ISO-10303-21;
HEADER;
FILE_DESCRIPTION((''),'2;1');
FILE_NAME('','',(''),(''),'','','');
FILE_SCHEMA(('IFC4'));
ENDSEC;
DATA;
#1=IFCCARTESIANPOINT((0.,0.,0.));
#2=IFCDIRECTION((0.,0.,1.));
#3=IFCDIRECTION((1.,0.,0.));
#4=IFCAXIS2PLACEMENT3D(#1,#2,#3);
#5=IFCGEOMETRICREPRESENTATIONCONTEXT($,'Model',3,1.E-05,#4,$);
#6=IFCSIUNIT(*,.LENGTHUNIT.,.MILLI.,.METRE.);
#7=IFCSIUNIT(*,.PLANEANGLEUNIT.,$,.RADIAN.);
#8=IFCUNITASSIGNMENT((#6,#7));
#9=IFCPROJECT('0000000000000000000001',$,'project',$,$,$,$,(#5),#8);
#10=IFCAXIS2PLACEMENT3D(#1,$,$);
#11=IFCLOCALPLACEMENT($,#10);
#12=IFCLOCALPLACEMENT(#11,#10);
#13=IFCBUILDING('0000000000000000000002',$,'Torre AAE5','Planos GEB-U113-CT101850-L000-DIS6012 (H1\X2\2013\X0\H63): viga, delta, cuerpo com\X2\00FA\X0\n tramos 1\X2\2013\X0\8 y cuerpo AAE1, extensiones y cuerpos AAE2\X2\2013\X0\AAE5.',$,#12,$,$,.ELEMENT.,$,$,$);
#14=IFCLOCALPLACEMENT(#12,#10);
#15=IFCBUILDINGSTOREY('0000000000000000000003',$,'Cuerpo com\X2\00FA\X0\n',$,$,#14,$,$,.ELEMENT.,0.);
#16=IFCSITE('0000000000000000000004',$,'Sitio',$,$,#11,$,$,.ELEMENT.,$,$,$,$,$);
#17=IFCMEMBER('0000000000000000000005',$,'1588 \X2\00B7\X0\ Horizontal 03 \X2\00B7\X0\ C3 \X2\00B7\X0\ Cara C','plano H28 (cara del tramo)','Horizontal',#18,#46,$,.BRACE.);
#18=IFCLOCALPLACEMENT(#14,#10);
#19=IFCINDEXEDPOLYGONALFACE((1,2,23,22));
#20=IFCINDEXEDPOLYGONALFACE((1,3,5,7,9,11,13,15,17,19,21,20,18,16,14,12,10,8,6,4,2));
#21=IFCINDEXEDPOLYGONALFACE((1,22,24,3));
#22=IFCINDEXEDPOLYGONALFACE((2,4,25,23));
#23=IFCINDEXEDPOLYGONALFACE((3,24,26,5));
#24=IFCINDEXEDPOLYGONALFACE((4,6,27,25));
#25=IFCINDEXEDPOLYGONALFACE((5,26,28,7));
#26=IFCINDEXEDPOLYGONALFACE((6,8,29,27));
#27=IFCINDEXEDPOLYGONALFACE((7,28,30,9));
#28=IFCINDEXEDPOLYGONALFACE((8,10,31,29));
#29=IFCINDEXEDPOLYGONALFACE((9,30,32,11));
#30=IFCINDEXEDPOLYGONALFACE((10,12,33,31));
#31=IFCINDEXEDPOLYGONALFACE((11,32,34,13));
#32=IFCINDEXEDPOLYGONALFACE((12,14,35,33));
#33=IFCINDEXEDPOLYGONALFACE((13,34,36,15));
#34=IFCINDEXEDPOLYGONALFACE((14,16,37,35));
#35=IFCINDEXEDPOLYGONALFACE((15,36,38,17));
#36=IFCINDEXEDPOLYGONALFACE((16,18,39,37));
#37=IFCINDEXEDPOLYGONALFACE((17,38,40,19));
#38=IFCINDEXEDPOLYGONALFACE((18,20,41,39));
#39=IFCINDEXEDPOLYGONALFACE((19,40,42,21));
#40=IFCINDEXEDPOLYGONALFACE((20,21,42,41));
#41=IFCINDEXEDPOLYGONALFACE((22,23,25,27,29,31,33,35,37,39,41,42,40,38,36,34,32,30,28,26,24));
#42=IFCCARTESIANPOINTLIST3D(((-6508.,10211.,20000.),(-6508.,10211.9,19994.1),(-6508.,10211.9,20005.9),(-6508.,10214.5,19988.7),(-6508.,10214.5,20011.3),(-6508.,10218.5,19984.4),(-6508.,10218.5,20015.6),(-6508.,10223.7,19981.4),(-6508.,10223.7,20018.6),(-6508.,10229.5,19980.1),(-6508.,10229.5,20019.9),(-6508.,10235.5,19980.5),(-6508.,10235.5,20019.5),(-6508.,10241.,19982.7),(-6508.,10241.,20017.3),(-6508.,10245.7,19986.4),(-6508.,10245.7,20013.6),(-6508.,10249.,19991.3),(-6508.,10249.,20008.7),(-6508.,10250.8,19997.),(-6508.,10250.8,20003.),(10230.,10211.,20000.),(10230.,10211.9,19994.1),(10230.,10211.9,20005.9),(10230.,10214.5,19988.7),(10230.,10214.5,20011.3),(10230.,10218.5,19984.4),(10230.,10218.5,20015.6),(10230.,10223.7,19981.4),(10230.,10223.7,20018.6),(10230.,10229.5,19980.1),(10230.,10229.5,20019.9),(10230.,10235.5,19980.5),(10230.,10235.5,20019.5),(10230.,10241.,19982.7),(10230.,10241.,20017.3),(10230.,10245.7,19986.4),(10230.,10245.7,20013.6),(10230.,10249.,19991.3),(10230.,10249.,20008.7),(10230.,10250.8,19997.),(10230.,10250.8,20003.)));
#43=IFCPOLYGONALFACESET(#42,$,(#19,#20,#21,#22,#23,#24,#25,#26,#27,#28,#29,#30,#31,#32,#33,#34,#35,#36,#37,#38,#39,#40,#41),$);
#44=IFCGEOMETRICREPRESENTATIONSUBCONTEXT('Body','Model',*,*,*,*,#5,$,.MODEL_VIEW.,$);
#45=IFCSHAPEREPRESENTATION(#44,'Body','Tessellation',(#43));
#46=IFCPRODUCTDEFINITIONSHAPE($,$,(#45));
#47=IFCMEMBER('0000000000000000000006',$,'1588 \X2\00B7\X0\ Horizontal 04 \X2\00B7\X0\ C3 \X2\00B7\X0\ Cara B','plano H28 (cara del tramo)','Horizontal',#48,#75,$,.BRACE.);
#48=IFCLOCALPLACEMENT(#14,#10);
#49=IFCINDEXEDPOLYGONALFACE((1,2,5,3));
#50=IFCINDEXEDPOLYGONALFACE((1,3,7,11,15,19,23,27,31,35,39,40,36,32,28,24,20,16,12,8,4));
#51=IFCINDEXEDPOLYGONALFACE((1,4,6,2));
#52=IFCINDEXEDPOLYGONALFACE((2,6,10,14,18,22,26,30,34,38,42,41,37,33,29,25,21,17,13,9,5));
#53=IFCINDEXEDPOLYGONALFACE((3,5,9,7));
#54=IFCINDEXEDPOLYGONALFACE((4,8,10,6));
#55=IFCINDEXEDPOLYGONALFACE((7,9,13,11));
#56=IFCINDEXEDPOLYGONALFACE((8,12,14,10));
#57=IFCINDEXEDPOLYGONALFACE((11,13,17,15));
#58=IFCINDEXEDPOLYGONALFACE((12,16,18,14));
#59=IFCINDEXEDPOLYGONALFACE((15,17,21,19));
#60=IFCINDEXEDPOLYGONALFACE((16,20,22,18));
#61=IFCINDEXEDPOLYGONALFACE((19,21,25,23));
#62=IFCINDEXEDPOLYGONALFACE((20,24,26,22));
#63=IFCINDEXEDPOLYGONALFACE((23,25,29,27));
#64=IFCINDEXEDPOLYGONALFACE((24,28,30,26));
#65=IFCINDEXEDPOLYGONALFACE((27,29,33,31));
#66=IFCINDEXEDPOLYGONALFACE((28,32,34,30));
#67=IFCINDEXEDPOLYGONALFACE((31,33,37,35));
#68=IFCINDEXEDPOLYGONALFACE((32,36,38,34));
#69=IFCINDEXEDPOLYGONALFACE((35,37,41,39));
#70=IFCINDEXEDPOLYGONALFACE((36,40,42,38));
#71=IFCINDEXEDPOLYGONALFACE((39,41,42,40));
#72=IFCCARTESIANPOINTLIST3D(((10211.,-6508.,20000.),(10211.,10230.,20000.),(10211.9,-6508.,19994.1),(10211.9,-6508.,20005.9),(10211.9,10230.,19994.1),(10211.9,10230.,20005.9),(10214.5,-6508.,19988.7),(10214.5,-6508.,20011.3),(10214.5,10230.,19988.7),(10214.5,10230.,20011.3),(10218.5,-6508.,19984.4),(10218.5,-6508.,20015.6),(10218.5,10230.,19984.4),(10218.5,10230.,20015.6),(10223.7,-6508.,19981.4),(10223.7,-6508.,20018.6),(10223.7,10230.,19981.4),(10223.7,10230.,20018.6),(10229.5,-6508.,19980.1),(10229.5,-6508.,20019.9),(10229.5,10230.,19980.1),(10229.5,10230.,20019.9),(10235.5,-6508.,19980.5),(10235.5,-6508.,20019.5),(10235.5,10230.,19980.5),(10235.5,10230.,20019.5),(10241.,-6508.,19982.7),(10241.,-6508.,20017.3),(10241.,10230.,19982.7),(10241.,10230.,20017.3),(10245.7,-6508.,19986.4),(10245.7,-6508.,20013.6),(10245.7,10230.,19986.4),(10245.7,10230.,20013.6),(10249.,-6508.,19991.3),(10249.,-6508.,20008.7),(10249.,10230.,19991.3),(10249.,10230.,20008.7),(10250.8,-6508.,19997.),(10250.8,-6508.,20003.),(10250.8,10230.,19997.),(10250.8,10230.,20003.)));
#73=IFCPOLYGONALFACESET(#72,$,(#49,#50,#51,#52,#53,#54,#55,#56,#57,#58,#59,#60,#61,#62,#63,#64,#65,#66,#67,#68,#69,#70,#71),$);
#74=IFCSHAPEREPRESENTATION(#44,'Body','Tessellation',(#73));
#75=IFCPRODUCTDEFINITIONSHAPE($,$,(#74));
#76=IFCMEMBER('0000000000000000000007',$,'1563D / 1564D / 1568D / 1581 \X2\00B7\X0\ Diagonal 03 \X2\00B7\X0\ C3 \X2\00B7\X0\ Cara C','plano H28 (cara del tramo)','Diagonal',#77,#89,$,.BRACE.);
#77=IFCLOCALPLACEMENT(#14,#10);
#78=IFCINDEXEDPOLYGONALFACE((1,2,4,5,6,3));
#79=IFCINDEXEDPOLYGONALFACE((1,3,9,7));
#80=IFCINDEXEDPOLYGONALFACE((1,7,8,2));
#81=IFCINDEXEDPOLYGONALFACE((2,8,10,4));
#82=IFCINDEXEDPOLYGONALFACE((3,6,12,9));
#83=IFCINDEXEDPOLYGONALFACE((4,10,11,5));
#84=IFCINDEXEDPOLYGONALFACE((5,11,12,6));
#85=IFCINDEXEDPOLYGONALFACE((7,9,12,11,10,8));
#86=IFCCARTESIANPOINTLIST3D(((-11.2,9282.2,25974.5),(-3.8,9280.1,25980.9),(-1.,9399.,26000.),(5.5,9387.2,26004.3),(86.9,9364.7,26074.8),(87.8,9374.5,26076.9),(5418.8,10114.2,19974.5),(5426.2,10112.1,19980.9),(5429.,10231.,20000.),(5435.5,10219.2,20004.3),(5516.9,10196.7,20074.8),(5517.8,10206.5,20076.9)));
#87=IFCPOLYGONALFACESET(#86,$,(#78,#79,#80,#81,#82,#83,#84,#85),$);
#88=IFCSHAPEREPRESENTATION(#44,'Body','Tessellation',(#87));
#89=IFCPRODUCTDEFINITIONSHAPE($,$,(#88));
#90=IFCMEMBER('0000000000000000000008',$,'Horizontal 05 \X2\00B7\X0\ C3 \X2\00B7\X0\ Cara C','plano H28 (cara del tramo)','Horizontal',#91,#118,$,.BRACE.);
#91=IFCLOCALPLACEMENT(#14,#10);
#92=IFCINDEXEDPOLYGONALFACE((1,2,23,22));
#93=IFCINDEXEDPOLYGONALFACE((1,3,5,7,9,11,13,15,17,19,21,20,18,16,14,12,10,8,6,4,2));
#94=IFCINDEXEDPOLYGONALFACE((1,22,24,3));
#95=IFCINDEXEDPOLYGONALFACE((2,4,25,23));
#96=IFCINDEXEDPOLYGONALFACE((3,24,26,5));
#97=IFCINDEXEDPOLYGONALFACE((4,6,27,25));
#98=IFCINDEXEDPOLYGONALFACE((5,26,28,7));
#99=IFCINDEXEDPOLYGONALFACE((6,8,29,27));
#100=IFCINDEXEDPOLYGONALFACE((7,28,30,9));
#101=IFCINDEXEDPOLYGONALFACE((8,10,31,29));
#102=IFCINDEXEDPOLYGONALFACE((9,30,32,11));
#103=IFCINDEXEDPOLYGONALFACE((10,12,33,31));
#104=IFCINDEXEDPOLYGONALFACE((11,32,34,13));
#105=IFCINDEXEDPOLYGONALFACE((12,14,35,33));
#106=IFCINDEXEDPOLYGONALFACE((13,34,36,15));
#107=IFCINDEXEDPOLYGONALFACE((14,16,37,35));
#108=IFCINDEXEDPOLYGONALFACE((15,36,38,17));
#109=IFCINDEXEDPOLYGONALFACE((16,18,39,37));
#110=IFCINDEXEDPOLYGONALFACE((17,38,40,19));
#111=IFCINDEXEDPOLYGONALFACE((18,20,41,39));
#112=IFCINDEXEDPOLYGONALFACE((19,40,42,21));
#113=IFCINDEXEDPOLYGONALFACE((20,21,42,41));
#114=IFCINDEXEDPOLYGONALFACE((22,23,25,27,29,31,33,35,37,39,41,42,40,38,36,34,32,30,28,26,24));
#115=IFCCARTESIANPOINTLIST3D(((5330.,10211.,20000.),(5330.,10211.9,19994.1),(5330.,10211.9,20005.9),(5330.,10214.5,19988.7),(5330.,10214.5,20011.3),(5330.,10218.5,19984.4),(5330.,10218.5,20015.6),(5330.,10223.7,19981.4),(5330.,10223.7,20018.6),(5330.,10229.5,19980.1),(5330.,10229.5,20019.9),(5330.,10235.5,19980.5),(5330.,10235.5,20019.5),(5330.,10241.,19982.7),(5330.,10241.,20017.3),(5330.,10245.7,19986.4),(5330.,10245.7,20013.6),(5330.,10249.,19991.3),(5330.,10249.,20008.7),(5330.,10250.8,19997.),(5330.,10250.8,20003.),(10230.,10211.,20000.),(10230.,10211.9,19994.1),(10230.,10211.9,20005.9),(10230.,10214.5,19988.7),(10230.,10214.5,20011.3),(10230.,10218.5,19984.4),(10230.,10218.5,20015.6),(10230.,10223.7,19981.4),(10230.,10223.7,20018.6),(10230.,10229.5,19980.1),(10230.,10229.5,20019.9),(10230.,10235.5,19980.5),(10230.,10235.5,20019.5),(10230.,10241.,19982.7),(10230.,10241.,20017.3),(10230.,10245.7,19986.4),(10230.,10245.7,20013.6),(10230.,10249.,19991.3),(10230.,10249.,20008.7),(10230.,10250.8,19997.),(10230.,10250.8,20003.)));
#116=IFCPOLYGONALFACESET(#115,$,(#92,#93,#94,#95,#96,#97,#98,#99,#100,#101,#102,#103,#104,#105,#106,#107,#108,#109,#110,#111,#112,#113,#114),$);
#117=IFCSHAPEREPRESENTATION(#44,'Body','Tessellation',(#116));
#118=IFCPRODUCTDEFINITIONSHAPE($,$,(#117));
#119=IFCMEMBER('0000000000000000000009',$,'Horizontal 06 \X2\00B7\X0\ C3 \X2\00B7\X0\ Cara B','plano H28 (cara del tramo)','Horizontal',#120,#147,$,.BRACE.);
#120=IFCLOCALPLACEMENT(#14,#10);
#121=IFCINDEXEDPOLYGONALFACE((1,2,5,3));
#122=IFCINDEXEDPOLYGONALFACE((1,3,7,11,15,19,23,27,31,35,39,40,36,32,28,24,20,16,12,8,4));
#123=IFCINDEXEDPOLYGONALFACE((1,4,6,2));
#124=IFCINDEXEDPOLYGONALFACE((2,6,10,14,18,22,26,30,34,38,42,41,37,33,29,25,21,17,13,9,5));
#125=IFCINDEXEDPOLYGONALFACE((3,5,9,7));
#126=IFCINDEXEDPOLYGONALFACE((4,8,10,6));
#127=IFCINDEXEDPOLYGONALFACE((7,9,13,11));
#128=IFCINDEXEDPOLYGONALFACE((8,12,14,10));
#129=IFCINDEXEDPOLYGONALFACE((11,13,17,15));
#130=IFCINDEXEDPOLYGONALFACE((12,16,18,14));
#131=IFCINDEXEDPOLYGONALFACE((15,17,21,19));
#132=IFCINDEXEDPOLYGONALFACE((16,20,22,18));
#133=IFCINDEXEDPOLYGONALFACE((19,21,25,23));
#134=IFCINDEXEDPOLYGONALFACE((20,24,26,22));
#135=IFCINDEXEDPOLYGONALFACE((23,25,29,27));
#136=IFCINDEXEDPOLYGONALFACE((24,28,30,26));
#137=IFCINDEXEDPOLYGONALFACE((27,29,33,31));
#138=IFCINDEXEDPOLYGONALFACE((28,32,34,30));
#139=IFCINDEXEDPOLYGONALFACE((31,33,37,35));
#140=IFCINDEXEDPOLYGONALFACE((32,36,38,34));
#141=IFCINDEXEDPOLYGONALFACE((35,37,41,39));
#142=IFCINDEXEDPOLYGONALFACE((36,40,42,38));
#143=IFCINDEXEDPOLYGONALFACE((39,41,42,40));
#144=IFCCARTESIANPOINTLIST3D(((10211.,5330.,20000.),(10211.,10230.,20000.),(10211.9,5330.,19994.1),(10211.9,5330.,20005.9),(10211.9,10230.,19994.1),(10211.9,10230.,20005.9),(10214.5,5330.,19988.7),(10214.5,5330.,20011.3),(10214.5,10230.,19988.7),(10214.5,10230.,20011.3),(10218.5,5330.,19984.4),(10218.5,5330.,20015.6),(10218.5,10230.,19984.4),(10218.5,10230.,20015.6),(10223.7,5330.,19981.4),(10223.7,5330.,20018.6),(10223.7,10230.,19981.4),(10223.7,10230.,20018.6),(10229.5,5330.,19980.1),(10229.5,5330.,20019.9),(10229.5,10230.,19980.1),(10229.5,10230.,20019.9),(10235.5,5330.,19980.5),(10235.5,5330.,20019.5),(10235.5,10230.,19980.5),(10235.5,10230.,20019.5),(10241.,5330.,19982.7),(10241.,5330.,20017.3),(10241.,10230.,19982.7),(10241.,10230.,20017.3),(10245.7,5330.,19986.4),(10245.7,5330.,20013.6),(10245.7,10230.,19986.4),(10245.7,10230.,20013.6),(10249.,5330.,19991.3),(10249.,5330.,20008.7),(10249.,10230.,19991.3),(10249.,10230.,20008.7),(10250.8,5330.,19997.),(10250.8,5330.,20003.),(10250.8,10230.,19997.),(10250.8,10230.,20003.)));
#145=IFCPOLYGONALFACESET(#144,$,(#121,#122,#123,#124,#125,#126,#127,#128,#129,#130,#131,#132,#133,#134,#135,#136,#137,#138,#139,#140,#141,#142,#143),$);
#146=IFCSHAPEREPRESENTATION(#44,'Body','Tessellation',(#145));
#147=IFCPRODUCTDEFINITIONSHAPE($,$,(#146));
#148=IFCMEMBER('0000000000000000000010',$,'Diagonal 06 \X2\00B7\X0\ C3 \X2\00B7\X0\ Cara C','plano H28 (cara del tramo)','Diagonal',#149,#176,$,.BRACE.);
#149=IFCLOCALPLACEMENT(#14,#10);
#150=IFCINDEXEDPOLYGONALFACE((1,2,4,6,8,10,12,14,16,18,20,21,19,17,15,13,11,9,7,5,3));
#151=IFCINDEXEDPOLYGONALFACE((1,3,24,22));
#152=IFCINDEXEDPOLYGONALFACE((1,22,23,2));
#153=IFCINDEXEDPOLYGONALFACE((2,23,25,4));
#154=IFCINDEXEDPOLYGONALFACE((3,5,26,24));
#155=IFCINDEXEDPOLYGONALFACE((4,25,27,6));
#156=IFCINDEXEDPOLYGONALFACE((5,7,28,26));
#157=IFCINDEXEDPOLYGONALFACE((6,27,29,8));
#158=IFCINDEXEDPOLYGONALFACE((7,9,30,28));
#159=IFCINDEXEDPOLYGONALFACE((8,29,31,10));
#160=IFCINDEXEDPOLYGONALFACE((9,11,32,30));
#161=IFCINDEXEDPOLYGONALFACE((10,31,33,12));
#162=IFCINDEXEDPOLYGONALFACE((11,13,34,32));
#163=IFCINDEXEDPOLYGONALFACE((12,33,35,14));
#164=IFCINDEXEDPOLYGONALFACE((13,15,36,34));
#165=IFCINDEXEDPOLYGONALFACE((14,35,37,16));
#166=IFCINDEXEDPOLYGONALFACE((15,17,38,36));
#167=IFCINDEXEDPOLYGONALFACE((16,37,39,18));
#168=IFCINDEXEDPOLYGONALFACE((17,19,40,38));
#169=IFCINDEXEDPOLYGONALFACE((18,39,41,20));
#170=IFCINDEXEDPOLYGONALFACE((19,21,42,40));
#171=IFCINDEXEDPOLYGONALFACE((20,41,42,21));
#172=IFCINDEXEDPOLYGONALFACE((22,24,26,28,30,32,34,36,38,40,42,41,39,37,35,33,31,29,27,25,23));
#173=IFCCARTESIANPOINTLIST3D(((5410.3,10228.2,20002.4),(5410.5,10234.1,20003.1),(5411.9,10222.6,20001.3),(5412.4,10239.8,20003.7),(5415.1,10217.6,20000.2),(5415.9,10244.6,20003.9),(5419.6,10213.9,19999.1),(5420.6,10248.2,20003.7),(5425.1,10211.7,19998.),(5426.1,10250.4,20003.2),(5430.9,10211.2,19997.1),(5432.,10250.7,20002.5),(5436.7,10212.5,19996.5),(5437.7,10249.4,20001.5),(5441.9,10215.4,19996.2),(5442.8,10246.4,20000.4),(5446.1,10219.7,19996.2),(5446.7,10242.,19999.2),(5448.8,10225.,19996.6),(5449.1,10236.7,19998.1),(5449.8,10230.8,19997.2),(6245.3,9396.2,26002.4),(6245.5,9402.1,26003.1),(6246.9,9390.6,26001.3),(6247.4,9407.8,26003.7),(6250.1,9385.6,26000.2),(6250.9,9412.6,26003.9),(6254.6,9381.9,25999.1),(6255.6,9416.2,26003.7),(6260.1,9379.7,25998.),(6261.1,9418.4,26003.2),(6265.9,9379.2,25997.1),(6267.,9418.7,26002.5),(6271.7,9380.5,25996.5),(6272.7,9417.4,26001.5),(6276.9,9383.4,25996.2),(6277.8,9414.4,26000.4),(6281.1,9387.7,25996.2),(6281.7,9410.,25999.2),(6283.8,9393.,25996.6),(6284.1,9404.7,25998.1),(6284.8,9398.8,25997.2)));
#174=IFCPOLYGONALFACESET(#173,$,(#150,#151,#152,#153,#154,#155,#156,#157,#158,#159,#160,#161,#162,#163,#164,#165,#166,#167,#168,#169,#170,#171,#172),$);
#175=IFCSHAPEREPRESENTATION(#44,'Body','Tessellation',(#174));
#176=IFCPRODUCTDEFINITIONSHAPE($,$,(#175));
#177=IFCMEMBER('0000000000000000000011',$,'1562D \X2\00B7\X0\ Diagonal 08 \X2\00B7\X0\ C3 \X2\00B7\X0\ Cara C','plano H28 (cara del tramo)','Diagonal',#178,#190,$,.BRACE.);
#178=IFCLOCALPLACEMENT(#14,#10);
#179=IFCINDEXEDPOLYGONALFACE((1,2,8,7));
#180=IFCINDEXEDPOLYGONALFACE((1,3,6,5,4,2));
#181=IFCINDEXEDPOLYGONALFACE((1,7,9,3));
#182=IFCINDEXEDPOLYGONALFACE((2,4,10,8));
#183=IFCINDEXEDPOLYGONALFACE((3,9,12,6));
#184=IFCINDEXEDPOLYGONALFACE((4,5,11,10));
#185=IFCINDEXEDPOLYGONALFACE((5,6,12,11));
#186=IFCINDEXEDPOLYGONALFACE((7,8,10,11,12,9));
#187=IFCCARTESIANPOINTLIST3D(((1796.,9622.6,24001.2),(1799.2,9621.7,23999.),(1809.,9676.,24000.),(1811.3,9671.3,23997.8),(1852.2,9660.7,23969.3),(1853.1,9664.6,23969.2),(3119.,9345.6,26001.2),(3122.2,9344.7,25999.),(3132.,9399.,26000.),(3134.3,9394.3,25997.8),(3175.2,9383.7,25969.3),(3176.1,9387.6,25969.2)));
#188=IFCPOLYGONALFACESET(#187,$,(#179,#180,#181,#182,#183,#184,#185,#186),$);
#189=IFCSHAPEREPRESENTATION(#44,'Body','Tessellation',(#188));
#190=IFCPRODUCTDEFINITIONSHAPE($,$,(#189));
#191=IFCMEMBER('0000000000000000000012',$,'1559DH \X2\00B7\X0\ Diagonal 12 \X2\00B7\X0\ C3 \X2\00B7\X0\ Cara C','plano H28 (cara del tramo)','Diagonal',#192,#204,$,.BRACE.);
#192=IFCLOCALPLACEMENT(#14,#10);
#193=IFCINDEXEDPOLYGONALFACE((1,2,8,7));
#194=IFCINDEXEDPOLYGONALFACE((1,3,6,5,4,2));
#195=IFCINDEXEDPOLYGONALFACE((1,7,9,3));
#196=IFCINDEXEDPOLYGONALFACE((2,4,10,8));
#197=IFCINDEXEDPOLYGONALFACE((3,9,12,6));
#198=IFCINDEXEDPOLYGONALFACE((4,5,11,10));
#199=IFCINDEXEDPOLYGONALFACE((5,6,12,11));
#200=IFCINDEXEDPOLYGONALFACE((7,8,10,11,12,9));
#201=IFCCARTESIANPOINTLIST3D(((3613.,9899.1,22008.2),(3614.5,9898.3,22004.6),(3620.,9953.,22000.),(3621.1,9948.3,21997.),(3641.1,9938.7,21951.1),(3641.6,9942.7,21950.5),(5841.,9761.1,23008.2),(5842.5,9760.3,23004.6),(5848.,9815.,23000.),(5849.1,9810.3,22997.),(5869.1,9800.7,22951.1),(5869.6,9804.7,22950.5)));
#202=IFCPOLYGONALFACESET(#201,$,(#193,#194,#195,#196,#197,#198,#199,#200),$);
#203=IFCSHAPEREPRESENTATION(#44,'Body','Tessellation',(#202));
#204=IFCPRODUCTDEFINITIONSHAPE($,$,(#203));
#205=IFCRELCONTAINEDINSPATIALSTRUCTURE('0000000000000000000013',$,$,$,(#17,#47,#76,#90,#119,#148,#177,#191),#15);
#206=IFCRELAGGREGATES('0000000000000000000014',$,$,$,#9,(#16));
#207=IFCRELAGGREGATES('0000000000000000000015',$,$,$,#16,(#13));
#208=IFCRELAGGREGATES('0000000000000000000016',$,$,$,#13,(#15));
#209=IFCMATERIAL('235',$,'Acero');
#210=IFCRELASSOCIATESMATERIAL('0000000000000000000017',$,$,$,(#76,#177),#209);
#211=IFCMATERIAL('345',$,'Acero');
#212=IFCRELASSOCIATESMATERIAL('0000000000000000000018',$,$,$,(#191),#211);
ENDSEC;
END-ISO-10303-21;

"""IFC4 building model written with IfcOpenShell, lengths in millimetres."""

from ifc_helpers import new_model, si_unit, frame, frame_2d, origin, origin_with_axes, place, context, subcontext, project, spatial, circle, l_section, extrude, material, element, save


model = new_model("IFC4")

# Units and contexts
model_context = context("Model", 3, precision=1e-05, world=origin_with_axes())
body_context = subcontext(model_context, "Body", "Model", "MODEL_VIEW")
ifc_project = project(units=[si_unit("LENGTHUNIT", "METRE", prefix="MILLI"), si_unit("PLANEANGLEUNIT", "RADIAN")], contexts=[model_context])

# Site, building, storey
site_placement = place(None, origin())
site = spatial("IfcSite", under=ifc_project, at=site_placement, Name="Sitio", CompositionType="ELEMENT")
building_placement = place(site_placement, origin())
building = spatial("IfcBuilding", under=site, at=building_placement, Name="Torre AAE5", Description="Planos GEB-U113-CT101850-L000-DIS6012 (H1–H63): viga, delta, cuerpo común tramos 1–8 y cuerpo AAE1, extensiones y cuerpos AAE2–AAE5.", CompositionType="ELEMENT")
storey_placement = place(building_placement, origin())
storey = spatial("IfcBuildingStorey", under=building, at=storey_placement, Name="Cuerpo común", CompositionType="ELEMENT", Elevation=0.0)

# Members
for number, where, z_axis, x_axis, name in (
    (1, (10230.0, 10231.0, 20000.0), (-1.0, 0.0, 0.0), (0.0, -1.0, 0.0), "1588 · Horizontal 03 · C3 · Cara C"),
    (2, (10231.0, 10230.0, 20000.0), (0.0, -1.0, 0.0), (-1.0, 0.0, 0.0), "1588 · Horizontal 04 · C3 · Cara B"),
):
    element("IfcMember", number, at=place(storey_placement, frame(where, z_axis=z_axis, x_axis=x_axis)), inside=storey, Name=name, Description="plano H28 (cara del tramo)", ObjectType="Horizontal", PredefinedType="BRACE", context=body_context, shape_type="SweptSolid", body=[
        extrude(circle(Radius=20.0), None, (0.0, 0.0, 1.0), 16738.0),
    ])
ifc_material_1 = material(Name="235", Category="Acero")
member_1_placement = place(storey_placement, frame((5429.0, 10231.0, 20000.0), z_axis=(-0.667492, -0.102275, 0.73756), x_axis=(-0.085296, -0.9735, -0.212185)))
element("IfcMember", 3, at=member_1_placement, inside=storey, material=ifc_material_1, Name="1563D / 1564D / 1568D / 1581 · Diagonal 03 · C3 · Cara C", Description="plano H28 (cara del tramo)", ObjectType="Diagonal", PredefinedType="BRACE", context=body_context, shape_type="SweptSolid", body=[
    extrude(l_section(Depth=120.0, Width=120.0, Thickness=10.0, at=frame_2d((60.0, 60.0))), None, (0.0, 0.0, 1.0), 8134.9),
])
for number, where, z_axis, x_axis, name in (
    (4, (10230.0, 10231.0, 20000.0), (-1.0, 0.0, 0.0), (0.0, -1.0, 0.0), "Horizontal 05 · C3 · Cara C"),
    (5, (10231.0, 10230.0, 20000.0), (0.0, -1.0, 0.0), (-1.0, 0.0, 0.0), "Horizontal 06 · C3 · Cara B"),
):
    element("IfcMember", number, at=place(storey_placement, frame(where, z_axis=z_axis, x_axis=x_axis)), inside=storey, Name=name, Description="plano H28 (cara del tramo)", ObjectType="Horizontal", PredefinedType="BRACE", context=body_context, shape_type="SweptSolid", body=[
        extrude(circle(Radius=20.0), None, (0.0, 0.0, 1.0), 4900.0),
    ])
member_2_placement = place(storey_placement, frame((5430.0, 10231.0, 20000.0), z_axis=(0.136556, -0.136066, 0.981243), x_axis=(-0.518814, -0.85364, -0.04617)))
element("IfcMember", 6, at=member_2_placement, inside=storey, Name="Diagonal 06 · C3 · Cara C", Description="plano H28 (cara del tramo)", ObjectType="Diagonal", PredefinedType="BRACE", context=body_context, shape_type="SweptSolid", body=[
    extrude(circle(Radius=20.0), None, (0.0, 0.0, 1.0), 6114.7),
])
member_3_placement = place(storey_placement, frame((1809.0, 9676.0, 24000.0), z_axis=(0.548069, -0.114751, 0.828524), x_axis=(-0.236397, -0.971411, 0.021836)))
element("IfcMember", 7, at=member_3_placement, inside=storey, material=ifc_material_1, Name="1562D · Diagonal 08 · C3 · Cara C", Description="plano H28 (cara del tramo)", ObjectType="Diagonal", PredefinedType="BRACE", context=body_context, shape_type="SweptSolid", body=[
    extrude(l_section(Depth=55.0, Width=55.0, Thickness=4.0, at=frame_2d((27.5, 27.5))), None, (0.0, 0.0, 1.0), 2413.9),
])
ifc_material_2 = material(Name="345", Category="Acero")
member_4_placement = place(storey_placement, frame((3620.0, 9953.0, 22000.0), z_axis=(0.910866, -0.056418, 0.408827), x_axis=(-0.127645, -0.980552, 0.149077)))
element("IfcMember", 8, at=member_4_placement, inside=storey, material=ifc_material_2, Name="1559DH · Diagonal 12 · C3 · Cara C", Description="plano H28 (cara del tramo)", ObjectType="Diagonal", PredefinedType="BRACE", context=body_context, shape_type="SweptSolid", body=[
    extrude(l_section(Depth=55.0, Width=55.0, Thickness=4.0, at=frame_2d((27.5, 27.5))), None, (0.0, 0.0, 1.0), 2446.0),
])

save(model, "model.ifc")
